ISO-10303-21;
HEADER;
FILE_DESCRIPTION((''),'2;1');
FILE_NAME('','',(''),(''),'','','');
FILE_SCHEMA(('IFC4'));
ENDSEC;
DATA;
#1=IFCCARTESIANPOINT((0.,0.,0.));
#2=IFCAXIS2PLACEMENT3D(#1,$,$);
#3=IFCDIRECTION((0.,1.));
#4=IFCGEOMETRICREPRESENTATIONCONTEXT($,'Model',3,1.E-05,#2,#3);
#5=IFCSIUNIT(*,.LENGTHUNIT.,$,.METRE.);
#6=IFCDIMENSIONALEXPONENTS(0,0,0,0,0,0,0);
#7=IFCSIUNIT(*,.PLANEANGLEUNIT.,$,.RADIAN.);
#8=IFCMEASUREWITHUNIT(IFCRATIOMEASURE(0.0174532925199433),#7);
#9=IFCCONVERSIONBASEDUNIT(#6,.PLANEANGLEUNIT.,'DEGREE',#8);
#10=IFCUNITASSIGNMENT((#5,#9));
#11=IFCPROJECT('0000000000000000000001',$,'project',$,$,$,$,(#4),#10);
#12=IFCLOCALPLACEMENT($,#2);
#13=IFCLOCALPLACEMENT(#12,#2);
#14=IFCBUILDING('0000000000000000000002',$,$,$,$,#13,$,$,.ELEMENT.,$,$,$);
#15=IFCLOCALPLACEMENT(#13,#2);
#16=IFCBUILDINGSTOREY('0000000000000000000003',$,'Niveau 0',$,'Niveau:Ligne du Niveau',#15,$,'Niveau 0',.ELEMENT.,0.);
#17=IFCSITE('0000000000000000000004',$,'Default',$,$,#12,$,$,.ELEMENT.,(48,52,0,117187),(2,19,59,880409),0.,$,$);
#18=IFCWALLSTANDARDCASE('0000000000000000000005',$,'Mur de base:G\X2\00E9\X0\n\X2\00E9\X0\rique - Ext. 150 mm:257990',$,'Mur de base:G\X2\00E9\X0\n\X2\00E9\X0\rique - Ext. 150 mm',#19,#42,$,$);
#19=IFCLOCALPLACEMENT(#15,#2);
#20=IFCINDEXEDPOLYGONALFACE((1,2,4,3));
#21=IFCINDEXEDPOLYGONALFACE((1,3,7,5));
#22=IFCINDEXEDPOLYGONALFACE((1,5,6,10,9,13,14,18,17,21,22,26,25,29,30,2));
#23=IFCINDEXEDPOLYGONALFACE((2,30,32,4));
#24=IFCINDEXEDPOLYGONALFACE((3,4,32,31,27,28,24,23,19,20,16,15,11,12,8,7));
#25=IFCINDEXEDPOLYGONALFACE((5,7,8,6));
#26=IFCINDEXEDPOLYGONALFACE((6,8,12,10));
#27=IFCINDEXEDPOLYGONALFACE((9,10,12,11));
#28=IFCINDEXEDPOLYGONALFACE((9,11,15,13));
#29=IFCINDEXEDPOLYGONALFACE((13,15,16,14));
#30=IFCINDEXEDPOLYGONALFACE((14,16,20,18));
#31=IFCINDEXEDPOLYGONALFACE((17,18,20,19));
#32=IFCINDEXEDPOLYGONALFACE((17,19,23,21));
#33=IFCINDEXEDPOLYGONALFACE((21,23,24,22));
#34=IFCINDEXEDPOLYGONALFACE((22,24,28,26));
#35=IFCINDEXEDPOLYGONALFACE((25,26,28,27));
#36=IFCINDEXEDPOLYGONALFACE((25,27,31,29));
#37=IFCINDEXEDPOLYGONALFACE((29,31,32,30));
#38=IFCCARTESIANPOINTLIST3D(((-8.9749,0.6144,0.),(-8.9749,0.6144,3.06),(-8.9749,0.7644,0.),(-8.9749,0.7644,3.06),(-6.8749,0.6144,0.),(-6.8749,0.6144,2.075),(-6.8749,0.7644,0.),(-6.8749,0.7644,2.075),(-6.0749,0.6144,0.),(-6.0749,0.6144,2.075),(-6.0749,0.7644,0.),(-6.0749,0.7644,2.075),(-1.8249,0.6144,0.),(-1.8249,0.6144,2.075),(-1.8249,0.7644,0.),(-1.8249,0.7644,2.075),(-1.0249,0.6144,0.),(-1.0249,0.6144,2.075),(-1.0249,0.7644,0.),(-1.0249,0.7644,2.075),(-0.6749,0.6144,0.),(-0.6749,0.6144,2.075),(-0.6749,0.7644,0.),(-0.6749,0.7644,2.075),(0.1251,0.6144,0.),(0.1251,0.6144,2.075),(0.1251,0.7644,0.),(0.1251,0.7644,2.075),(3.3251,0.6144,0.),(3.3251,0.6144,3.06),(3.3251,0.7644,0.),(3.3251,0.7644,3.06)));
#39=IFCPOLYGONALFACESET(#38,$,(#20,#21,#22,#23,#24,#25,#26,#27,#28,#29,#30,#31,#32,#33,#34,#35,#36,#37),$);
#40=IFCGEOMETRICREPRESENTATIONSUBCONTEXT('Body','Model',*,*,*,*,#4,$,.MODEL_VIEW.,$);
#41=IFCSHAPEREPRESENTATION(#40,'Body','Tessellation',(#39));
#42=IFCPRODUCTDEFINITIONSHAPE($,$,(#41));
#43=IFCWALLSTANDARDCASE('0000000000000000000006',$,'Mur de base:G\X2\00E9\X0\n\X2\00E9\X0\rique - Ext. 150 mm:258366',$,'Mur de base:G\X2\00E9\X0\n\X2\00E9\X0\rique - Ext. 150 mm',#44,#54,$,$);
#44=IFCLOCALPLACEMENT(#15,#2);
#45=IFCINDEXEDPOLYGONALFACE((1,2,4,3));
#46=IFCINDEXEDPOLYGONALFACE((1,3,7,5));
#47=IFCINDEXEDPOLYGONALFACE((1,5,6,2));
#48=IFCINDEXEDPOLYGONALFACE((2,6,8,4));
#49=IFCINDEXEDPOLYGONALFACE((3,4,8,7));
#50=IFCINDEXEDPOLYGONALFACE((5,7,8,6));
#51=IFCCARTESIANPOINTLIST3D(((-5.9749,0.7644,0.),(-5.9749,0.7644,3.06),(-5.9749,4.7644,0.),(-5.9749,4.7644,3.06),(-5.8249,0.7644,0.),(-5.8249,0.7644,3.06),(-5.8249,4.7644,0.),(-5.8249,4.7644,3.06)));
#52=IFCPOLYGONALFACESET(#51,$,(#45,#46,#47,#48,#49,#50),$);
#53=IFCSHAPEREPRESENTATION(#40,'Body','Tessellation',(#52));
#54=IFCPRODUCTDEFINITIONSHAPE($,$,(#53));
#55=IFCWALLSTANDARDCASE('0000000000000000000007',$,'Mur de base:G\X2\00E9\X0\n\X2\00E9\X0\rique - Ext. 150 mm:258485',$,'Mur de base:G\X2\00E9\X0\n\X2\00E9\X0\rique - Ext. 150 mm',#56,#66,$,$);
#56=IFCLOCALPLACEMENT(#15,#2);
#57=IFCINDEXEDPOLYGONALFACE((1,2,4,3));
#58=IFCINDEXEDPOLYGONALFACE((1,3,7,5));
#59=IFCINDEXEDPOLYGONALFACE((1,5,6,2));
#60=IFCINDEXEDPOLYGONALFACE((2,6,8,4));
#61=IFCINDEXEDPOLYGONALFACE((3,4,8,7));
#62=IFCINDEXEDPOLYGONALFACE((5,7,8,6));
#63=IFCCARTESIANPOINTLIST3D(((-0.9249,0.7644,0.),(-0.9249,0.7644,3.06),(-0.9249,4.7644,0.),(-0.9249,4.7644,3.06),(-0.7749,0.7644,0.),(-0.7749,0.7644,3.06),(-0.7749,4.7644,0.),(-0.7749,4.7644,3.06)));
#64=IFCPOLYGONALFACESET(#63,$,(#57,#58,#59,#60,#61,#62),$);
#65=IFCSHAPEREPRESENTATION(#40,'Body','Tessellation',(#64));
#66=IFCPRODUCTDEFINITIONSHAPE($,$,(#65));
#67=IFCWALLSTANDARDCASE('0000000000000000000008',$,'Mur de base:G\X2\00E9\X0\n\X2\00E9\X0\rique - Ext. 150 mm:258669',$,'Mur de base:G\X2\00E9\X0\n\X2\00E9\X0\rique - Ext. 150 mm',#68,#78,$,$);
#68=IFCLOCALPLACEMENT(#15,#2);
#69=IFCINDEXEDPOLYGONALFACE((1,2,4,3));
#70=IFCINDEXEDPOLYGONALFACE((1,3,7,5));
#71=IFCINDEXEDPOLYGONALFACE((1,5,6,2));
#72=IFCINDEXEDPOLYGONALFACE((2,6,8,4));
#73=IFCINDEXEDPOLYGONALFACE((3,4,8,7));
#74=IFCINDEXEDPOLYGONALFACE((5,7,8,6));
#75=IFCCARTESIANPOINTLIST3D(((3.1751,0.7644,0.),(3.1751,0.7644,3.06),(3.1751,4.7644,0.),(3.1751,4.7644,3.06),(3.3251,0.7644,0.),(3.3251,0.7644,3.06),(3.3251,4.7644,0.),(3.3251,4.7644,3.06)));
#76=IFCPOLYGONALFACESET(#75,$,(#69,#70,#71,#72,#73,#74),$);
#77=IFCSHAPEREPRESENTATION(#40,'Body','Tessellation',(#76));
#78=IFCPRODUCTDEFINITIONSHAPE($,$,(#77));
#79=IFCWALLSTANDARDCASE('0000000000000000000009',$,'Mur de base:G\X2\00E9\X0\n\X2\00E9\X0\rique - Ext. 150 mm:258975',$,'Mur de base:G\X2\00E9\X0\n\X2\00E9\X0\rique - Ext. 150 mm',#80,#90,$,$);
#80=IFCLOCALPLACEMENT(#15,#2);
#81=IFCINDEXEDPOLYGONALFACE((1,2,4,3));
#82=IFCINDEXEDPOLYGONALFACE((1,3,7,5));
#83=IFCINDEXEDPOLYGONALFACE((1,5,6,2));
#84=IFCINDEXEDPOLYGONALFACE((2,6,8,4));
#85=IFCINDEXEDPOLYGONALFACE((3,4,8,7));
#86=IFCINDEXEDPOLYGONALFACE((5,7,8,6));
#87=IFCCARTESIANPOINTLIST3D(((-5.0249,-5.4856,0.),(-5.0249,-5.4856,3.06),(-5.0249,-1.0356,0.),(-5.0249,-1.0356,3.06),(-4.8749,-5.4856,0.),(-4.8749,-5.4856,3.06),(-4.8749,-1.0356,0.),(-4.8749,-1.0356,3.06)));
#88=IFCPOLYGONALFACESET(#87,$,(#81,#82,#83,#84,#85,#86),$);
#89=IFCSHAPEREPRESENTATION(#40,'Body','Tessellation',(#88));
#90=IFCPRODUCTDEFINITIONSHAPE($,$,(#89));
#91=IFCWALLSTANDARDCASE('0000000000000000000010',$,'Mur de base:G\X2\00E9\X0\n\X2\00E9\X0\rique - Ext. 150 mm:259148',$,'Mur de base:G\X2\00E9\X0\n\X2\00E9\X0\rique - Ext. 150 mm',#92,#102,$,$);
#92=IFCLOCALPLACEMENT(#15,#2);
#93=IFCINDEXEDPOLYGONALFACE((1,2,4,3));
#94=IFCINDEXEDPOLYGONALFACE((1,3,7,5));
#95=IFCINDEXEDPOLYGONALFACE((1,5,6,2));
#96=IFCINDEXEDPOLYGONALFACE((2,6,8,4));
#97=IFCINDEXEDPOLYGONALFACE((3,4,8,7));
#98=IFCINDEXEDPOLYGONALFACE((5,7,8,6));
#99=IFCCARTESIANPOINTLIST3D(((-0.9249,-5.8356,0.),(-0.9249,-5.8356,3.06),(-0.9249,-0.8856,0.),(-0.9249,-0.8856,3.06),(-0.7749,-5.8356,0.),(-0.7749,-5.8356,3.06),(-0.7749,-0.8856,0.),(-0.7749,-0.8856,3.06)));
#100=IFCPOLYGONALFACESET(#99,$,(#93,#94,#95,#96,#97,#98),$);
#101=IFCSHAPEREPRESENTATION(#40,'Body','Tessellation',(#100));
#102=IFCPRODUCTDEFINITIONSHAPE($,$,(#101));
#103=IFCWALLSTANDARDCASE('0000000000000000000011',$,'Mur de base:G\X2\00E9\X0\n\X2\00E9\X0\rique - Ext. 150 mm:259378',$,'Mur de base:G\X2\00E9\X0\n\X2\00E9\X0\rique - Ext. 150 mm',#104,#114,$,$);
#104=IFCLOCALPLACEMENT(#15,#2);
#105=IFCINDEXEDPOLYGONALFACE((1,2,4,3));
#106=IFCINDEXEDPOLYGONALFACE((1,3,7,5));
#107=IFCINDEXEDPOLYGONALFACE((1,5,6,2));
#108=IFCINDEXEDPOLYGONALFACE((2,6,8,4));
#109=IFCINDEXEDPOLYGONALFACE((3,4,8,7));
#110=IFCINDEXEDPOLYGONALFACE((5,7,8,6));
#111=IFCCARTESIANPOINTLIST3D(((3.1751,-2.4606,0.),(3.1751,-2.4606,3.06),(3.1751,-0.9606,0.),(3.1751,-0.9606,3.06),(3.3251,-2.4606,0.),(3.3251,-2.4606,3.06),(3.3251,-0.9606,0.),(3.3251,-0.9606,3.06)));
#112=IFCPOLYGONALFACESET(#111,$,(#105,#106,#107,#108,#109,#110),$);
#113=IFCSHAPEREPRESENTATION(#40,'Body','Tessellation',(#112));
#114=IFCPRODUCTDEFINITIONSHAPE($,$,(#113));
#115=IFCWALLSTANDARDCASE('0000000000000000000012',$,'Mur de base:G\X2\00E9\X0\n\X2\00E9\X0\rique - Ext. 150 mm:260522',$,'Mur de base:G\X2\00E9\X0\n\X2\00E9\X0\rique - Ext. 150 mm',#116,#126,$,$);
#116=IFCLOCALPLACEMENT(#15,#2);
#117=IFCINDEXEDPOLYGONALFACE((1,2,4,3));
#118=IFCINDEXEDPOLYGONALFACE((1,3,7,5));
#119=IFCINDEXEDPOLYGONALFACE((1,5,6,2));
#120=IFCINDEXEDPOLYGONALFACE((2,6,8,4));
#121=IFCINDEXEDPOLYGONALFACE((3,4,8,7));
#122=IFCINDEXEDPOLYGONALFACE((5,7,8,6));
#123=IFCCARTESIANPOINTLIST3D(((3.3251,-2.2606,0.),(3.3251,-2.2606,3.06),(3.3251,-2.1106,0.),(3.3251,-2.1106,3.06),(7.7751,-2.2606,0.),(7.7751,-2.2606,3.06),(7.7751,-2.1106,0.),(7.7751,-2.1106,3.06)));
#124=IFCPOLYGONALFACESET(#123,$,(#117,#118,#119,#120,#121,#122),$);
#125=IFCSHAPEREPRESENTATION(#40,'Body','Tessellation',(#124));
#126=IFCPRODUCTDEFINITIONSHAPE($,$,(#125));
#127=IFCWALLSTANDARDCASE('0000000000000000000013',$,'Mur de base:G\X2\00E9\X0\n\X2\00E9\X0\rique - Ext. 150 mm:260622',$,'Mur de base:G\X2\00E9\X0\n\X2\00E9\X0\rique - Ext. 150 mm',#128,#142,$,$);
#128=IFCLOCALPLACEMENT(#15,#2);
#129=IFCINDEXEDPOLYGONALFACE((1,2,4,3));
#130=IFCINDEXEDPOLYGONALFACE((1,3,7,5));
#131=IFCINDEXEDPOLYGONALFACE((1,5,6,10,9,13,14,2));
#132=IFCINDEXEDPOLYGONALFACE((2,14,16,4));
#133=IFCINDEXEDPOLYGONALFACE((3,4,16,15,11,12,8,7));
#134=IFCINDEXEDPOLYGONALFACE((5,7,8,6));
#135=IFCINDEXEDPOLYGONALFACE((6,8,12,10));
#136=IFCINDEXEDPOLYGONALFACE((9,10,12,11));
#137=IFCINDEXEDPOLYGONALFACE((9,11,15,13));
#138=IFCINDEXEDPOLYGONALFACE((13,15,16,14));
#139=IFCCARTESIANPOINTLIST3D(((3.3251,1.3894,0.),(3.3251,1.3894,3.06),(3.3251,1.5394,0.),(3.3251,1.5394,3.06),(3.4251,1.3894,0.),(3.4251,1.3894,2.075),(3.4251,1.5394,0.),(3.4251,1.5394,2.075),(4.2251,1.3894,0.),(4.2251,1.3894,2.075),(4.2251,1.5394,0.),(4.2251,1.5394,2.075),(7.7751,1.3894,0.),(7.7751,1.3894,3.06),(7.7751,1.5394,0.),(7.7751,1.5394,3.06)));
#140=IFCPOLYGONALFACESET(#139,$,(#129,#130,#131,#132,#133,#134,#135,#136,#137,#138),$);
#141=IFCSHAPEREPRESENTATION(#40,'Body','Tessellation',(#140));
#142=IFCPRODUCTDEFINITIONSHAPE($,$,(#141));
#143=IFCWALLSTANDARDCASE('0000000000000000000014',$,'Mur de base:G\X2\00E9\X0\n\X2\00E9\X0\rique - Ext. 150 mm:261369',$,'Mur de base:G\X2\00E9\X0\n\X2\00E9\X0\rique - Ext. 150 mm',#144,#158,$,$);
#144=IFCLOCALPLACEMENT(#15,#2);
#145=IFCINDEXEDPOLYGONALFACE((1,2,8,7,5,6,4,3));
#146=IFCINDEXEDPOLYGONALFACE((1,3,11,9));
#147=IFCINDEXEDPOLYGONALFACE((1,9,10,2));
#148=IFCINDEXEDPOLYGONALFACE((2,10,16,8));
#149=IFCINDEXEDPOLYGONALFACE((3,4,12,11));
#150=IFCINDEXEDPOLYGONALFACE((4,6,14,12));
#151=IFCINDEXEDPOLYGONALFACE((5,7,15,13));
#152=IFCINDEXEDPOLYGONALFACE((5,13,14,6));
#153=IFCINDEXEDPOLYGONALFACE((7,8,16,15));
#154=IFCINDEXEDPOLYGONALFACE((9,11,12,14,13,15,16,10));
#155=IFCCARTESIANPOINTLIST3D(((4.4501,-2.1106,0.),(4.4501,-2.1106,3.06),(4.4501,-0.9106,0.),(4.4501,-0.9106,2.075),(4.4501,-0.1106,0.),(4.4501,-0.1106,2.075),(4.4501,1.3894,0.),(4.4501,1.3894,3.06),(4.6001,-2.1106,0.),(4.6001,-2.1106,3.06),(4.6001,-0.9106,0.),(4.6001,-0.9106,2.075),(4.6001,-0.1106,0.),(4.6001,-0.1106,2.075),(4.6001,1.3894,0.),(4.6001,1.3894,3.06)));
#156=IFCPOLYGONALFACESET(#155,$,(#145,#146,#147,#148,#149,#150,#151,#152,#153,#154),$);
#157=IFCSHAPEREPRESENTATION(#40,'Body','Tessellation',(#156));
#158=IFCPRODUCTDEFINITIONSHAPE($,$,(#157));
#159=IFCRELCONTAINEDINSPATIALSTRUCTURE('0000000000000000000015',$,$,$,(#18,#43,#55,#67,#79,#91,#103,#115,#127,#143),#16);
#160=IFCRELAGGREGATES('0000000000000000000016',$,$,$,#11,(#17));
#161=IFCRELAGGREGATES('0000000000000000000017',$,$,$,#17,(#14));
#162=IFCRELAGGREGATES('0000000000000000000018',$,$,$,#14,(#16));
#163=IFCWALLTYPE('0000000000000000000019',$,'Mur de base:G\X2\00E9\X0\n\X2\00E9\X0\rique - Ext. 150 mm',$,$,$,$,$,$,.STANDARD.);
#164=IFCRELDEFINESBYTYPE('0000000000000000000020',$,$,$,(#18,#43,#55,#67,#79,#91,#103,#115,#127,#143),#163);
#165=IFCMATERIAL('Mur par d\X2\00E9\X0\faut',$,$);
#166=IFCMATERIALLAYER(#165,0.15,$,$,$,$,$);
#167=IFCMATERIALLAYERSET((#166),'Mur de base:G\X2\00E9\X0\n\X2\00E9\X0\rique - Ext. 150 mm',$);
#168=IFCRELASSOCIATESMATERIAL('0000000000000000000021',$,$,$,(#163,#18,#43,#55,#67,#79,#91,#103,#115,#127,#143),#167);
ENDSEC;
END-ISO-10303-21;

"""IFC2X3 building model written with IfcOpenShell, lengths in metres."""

from ifc_helpers import new_model, entity, si_unit, converted_unit, direction, frame, frame_2d, origin, place, context, subcontext, project, spatial, rectangle, extrude, material, layer, layer_set, layer_usage, type_object, element, save


model = new_model("IFC2X3")

# Units and contexts
model_context = context("Model", 3, precision=1e-05, world=origin(), true_north=direction((0.0, 1.0)))
body_context = subcontext(model_context, "Body", "Model", "MODEL_VIEW")
ifc_project = project(units=[si_unit("LENGTHUNIT", "METRE"), converted_unit("PLANEANGLEUNIT", "DEGREE", entity("IfcRatioMeasure", 0.0174532925199433), si_unit("PLANEANGLEUNIT", "RADIAN"), dimensions=[0, 0, 0, 0, 0, 0, 0])], contexts=[model_context])

# Site, building, storey
site_placement = place(None, origin())
site = spatial("IfcSite", under=ifc_project, at=site_placement, Name="Default", CompositionType="ELEMENT", RefLatitude=(48, 52, 0, 117187), RefLongitude=(2, 19, 59, 880409), RefElevation=0.0)
building_placement = place(site_placement, origin())
building = spatial("IfcBuilding", under=site, at=building_placement, CompositionType="ELEMENT")
storey_placement = place(building_placement, origin())
storey = spatial("IfcBuildingStorey", under=building, at=storey_placement, Name="Niveau 0", ObjectType="Niveau:Ligne du Niveau", LongName="Niveau 0", CompositionType="ELEMENT", Elevation=0.0)

# Shared definitions
ifc_material_1 = material(Name="Mur par défaut")
ifc_layer_1 = layer(ifc_material_1, 0.15)
ifc_layer_set_1 = layer_set([ifc_layer_1], Name="Mur de base:Générique - Ext. 150 mm")
wall_type = type_object("IfcWallType", Name="Mur de base:Générique - Ext. 150 mm", PredefinedType="STANDARD", material=ifc_layer_set_1)

# Wall, openings
ifc_layer_usage_1 = layer_usage(ifc_layer_set_1, "AXIS2", "NEGATIVE", 0.075)
wall_1_placement = place(storey_placement, frame((-8.9749, 0.6894, 0.0)))
wall_1 = element("IfcWallStandardCase", 1, at=wall_1_placement, inside=storey, type_object=wall_type, material=ifc_layer_usage_1, Name="Mur de base:Générique - Ext. 150 mm:257990", ObjectType="Mur de base:Générique - Ext. 150 mm", context=body_context, shape_type="SweptSolid", body=[
    extrude(rectangle(XDim=12.3, YDim=0.15, at=frame_2d((6.15, 0.0), x_axis=(-1.0, 0.0))), origin(), (0.0, 0.0, 1.0), 3.06),
])
opening_1_placement = place(wall_1_placement, frame((2.1, -0.075, 0.0)))
element("IfcOpeningElement", 2, at=opening_1_placement, cuts=wall_1, ObjectType="Opening", context=body_context, shape_type="SweptSolid", body=[
    extrude(rectangle(XDim=2.075, YDim=0.8, at=frame_2d((1.0375, 0.4), x_axis=(1.0, 0.0))), frame((0.0, 0.0, 0.0), z_axis=(0.0, 1.0, 0.0), x_axis=(0.0, 0.0, 1.0)), (0.0, 0.0, 1.0), 0.15),
])
opening_2_placement = place(wall_1_placement, frame((7.15, -0.075, 0.0)))
element("IfcOpeningElement", 3, at=opening_2_placement, cuts=wall_1, ObjectType="Opening", context=body_context, shape_type="SweptSolid", body=[
    extrude(rectangle(XDim=2.075, YDim=0.8, at=frame_2d((1.0375, 0.4), x_axis=(1.0, 0.0))), frame((0.0, 0.0, 0.0), z_axis=(0.0, 1.0, 0.0), x_axis=(0.0, 0.0, 1.0)), (0.0, 0.0, 1.0), 0.15),
])
opening_3_placement = place(wall_1_placement, frame((8.3, -0.075, 0.0)))
element("IfcOpeningElement", 4, at=opening_3_placement, cuts=wall_1, ObjectType="Opening", context=body_context, shape_type="SweptSolid", body=[
    extrude(rectangle(XDim=2.075, YDim=0.8, at=frame_2d((1.0375, 0.4), x_axis=(1.0, 0.0))), frame((0.0, 0.0, 0.0), z_axis=(0.0, 1.0, 0.0), x_axis=(0.0, 0.0, 1.0)), (0.0, 0.0, 1.0), 0.15),
])

# Walls
ifc_layer_usage_2 = layer_usage(ifc_layer_set_1, "AXIS2", "NEGATIVE", 0.075)
wall_2_placement = place(storey_placement, frame((-5.8999, 4.7644, 0.0), z_axis=(0.0, 0.0, 1.0), x_axis=(0.0, -1.0, 0.0)))
element("IfcWallStandardCase", 5, at=wall_2_placement, inside=storey, type_object=wall_type, material=ifc_layer_usage_2, Name="Mur de base:Générique - Ext. 150 mm:258366", ObjectType="Mur de base:Générique - Ext. 150 mm", context=body_context, shape_type="SweptSolid", body=[
    extrude(rectangle(XDim=4.0, YDim=0.15, at=frame_2d((2.0, 0.0), x_axis=(-1.0, 0.0))), origin(), (0.0, 0.0, 1.0), 3.06),
])
ifc_layer_usage_3 = layer_usage(ifc_layer_set_1, "AXIS2", "NEGATIVE", 0.075)
wall_3_placement = place(storey_placement, frame((-0.8499, 4.7644, 0.0), z_axis=(0.0, 0.0, 1.0), x_axis=(0.0, -1.0, 0.0)))
element("IfcWallStandardCase", 6, at=wall_3_placement, inside=storey, type_object=wall_type, material=ifc_layer_usage_3, Name="Mur de base:Générique - Ext. 150 mm:258485", ObjectType="Mur de base:Générique - Ext. 150 mm", context=body_context, shape_type="SweptSolid", body=[
    extrude(rectangle(XDim=4.0, YDim=0.15, at=frame_2d((2.0, 0.0), x_axis=(-1.0, 0.0))), origin(), (0.0, 0.0, 1.0), 3.06),
])
ifc_layer_usage_4 = layer_usage(ifc_layer_set_1, "AXIS2", "NEGATIVE", 0.075)
wall_4_placement = place(storey_placement, frame((3.2501, 4.7644, 0.0), z_axis=(0.0, 0.0, 1.0), x_axis=(0.0, -1.0, 0.0)))
element("IfcWallStandardCase", 7, at=wall_4_placement, inside=storey, type_object=wall_type, material=ifc_layer_usage_4, Name="Mur de base:Générique - Ext. 150 mm:258669", ObjectType="Mur de base:Générique - Ext. 150 mm", context=body_context, shape_type="SweptSolid", body=[
    extrude(rectangle(XDim=4.0, YDim=0.15, at=frame_2d((2.0, 0.0), x_axis=(-1.0, 0.0))), origin(), (0.0, 0.0, 1.0), 3.06),
])
ifc_layer_usage_5 = layer_usage(ifc_layer_set_1, "AXIS2", "NEGATIVE", 0.075)
wall_5_placement = place(storey_placement, frame((-4.9499, -1.0356, 0.0), z_axis=(0.0, 0.0, 1.0), x_axis=(0.0, -1.0, 0.0)))
element("IfcWallStandardCase", 8, at=wall_5_placement, inside=storey, type_object=wall_type, material=ifc_layer_usage_5, Name="Mur de base:Générique - Ext. 150 mm:258975", ObjectType="Mur de base:Générique - Ext. 150 mm", context=body_context, shape_type="SweptSolid", body=[
    extrude(rectangle(XDim=4.45, YDim=0.15, at=frame_2d((2.225, 0.0), x_axis=(-1.0, 0.0))), origin(), (0.0, 0.0, 1.0), 3.06),
])
ifc_layer_usage_6 = layer_usage(ifc_layer_set_1, "AXIS2", "NEGATIVE", 0.075)
wall_6_placement = place(storey_placement, frame((-0.8499, -0.8856, 0.0), z_axis=(0.0, 0.0, 1.0), x_axis=(0.0, -1.0, 0.0)))
element("IfcWallStandardCase", 9, at=wall_6_placement, inside=storey, type_object=wall_type, material=ifc_layer_usage_6, Name="Mur de base:Générique - Ext. 150 mm:259148", ObjectType="Mur de base:Générique - Ext. 150 mm", context=body_context, shape_type="SweptSolid", body=[
    extrude(rectangle(XDim=4.95, YDim=0.15, at=frame_2d((2.475, 0.0), x_axis=(-1.0, 0.0))), origin(), (0.0, 0.0, 1.0), 3.06),
])
ifc_layer_usage_7 = layer_usage(ifc_layer_set_1, "AXIS2", "NEGATIVE", 0.075)
wall_7_placement = place(storey_placement, frame((3.2501, -0.9606, 0.0), z_axis=(0.0, 0.0, 1.0), x_axis=(0.0, -1.0, 0.0)))
element("IfcWallStandardCase", 10, at=wall_7_placement, inside=storey, type_object=wall_type, material=ifc_layer_usage_7, Name="Mur de base:Générique - Ext. 150 mm:259378", ObjectType="Mur de base:Générique - Ext. 150 mm", context=body_context, shape_type="SweptSolid", body=[
    extrude(rectangle(XDim=1.5, YDim=0.15, at=frame_2d((0.75, 0.0), x_axis=(-1.0, 0.0))), origin(), (0.0, 0.0, 1.0), 3.06),
])
ifc_layer_usage_8 = layer_usage(ifc_layer_set_1, "AXIS2", "NEGATIVE", 0.075)
wall_8_placement = place(storey_placement, frame((3.3251, -2.1856, 0.0)))
element("IfcWallStandardCase", 11, at=wall_8_placement, inside=storey, type_object=wall_type, material=ifc_layer_usage_8, Name="Mur de base:Générique - Ext. 150 mm:260522", ObjectType="Mur de base:Générique - Ext. 150 mm", context=body_context, shape_type="SweptSolid", body=[
    extrude(rectangle(XDim=4.45, YDim=0.15, at=frame_2d((2.225, 0.0), x_axis=(-1.0, 0.0))), origin(), (0.0, 0.0, 1.0), 3.06),
])

# Walls, openings
ifc_layer_usage_9 = layer_usage(ifc_layer_set_1, "AXIS2", "NEGATIVE", 0.075)
wall_9_placement = place(storey_placement, frame((3.3251, 1.4644, 0.0)))
wall_9 = element("IfcWallStandardCase", 12, at=wall_9_placement, inside=storey, type_object=wall_type, material=ifc_layer_usage_9, Name="Mur de base:Générique - Ext. 150 mm:260622", ObjectType="Mur de base:Générique - Ext. 150 mm", context=body_context, shape_type="SweptSolid", body=[
    extrude(rectangle(XDim=4.45, YDim=0.15, at=frame_2d((2.225, 0.0), x_axis=(-1.0, 0.0))), origin(), (0.0, 0.0, 1.0), 3.06),
])
opening_4_placement = place(wall_9_placement, frame((0.1, -0.075, 0.0)))
element("IfcOpeningElement", 13, at=opening_4_placement, cuts=wall_9, ObjectType="Opening", context=body_context, shape_type="SweptSolid", body=[
    extrude(rectangle(XDim=2.075, YDim=0.8, at=frame_2d((1.0375, 0.4), x_axis=(1.0, 0.0))), frame((0.0, 0.0, 0.0), z_axis=(0.0, 1.0, 0.0), x_axis=(0.0, 0.0, 1.0)), (0.0, 0.0, 1.0), 0.15),
])
ifc_layer_usage_10 = layer_usage(ifc_layer_set_1, "AXIS2", "NEGATIVE", 0.075)
wall_10_placement = place(storey_placement, frame((4.5251, 1.3894, 0.0), z_axis=(0.0, 0.0, 1.0), x_axis=(0.0, -1.0, 0.0)))
wall_10 = element("IfcWallStandardCase", 14, at=wall_10_placement, inside=storey, type_object=wall_type, material=ifc_layer_usage_10, Name="Mur de base:Générique - Ext. 150 mm:261369", ObjectType="Mur de base:Générique - Ext. 150 mm", context=body_context, shape_type="SweptSolid", body=[
    extrude(rectangle(XDim=3.5, YDim=0.15, at=frame_2d((1.75, 0.0), x_axis=(-1.0, 0.0))), origin(), (0.0, 0.0, 1.0), 3.06),
])
opening_5_placement = place(wall_10_placement, frame((1.5, -0.075, 0.0)))
element("IfcOpeningElement", 15, at=opening_5_placement, cuts=wall_10, ObjectType="Opening", context=body_context, shape_type="SweptSolid", body=[
    extrude(rectangle(XDim=2.075, YDim=0.8, at=frame_2d((1.0375, 0.4), x_axis=(1.0, 0.0))), frame((0.0, 0.0, 0.0), z_axis=(0.0, 1.0, 0.0), x_axis=(0.0, 0.0, 1.0)), (0.0, 0.0, 1.0), 0.15),
])

save(model, "model.ifc")
